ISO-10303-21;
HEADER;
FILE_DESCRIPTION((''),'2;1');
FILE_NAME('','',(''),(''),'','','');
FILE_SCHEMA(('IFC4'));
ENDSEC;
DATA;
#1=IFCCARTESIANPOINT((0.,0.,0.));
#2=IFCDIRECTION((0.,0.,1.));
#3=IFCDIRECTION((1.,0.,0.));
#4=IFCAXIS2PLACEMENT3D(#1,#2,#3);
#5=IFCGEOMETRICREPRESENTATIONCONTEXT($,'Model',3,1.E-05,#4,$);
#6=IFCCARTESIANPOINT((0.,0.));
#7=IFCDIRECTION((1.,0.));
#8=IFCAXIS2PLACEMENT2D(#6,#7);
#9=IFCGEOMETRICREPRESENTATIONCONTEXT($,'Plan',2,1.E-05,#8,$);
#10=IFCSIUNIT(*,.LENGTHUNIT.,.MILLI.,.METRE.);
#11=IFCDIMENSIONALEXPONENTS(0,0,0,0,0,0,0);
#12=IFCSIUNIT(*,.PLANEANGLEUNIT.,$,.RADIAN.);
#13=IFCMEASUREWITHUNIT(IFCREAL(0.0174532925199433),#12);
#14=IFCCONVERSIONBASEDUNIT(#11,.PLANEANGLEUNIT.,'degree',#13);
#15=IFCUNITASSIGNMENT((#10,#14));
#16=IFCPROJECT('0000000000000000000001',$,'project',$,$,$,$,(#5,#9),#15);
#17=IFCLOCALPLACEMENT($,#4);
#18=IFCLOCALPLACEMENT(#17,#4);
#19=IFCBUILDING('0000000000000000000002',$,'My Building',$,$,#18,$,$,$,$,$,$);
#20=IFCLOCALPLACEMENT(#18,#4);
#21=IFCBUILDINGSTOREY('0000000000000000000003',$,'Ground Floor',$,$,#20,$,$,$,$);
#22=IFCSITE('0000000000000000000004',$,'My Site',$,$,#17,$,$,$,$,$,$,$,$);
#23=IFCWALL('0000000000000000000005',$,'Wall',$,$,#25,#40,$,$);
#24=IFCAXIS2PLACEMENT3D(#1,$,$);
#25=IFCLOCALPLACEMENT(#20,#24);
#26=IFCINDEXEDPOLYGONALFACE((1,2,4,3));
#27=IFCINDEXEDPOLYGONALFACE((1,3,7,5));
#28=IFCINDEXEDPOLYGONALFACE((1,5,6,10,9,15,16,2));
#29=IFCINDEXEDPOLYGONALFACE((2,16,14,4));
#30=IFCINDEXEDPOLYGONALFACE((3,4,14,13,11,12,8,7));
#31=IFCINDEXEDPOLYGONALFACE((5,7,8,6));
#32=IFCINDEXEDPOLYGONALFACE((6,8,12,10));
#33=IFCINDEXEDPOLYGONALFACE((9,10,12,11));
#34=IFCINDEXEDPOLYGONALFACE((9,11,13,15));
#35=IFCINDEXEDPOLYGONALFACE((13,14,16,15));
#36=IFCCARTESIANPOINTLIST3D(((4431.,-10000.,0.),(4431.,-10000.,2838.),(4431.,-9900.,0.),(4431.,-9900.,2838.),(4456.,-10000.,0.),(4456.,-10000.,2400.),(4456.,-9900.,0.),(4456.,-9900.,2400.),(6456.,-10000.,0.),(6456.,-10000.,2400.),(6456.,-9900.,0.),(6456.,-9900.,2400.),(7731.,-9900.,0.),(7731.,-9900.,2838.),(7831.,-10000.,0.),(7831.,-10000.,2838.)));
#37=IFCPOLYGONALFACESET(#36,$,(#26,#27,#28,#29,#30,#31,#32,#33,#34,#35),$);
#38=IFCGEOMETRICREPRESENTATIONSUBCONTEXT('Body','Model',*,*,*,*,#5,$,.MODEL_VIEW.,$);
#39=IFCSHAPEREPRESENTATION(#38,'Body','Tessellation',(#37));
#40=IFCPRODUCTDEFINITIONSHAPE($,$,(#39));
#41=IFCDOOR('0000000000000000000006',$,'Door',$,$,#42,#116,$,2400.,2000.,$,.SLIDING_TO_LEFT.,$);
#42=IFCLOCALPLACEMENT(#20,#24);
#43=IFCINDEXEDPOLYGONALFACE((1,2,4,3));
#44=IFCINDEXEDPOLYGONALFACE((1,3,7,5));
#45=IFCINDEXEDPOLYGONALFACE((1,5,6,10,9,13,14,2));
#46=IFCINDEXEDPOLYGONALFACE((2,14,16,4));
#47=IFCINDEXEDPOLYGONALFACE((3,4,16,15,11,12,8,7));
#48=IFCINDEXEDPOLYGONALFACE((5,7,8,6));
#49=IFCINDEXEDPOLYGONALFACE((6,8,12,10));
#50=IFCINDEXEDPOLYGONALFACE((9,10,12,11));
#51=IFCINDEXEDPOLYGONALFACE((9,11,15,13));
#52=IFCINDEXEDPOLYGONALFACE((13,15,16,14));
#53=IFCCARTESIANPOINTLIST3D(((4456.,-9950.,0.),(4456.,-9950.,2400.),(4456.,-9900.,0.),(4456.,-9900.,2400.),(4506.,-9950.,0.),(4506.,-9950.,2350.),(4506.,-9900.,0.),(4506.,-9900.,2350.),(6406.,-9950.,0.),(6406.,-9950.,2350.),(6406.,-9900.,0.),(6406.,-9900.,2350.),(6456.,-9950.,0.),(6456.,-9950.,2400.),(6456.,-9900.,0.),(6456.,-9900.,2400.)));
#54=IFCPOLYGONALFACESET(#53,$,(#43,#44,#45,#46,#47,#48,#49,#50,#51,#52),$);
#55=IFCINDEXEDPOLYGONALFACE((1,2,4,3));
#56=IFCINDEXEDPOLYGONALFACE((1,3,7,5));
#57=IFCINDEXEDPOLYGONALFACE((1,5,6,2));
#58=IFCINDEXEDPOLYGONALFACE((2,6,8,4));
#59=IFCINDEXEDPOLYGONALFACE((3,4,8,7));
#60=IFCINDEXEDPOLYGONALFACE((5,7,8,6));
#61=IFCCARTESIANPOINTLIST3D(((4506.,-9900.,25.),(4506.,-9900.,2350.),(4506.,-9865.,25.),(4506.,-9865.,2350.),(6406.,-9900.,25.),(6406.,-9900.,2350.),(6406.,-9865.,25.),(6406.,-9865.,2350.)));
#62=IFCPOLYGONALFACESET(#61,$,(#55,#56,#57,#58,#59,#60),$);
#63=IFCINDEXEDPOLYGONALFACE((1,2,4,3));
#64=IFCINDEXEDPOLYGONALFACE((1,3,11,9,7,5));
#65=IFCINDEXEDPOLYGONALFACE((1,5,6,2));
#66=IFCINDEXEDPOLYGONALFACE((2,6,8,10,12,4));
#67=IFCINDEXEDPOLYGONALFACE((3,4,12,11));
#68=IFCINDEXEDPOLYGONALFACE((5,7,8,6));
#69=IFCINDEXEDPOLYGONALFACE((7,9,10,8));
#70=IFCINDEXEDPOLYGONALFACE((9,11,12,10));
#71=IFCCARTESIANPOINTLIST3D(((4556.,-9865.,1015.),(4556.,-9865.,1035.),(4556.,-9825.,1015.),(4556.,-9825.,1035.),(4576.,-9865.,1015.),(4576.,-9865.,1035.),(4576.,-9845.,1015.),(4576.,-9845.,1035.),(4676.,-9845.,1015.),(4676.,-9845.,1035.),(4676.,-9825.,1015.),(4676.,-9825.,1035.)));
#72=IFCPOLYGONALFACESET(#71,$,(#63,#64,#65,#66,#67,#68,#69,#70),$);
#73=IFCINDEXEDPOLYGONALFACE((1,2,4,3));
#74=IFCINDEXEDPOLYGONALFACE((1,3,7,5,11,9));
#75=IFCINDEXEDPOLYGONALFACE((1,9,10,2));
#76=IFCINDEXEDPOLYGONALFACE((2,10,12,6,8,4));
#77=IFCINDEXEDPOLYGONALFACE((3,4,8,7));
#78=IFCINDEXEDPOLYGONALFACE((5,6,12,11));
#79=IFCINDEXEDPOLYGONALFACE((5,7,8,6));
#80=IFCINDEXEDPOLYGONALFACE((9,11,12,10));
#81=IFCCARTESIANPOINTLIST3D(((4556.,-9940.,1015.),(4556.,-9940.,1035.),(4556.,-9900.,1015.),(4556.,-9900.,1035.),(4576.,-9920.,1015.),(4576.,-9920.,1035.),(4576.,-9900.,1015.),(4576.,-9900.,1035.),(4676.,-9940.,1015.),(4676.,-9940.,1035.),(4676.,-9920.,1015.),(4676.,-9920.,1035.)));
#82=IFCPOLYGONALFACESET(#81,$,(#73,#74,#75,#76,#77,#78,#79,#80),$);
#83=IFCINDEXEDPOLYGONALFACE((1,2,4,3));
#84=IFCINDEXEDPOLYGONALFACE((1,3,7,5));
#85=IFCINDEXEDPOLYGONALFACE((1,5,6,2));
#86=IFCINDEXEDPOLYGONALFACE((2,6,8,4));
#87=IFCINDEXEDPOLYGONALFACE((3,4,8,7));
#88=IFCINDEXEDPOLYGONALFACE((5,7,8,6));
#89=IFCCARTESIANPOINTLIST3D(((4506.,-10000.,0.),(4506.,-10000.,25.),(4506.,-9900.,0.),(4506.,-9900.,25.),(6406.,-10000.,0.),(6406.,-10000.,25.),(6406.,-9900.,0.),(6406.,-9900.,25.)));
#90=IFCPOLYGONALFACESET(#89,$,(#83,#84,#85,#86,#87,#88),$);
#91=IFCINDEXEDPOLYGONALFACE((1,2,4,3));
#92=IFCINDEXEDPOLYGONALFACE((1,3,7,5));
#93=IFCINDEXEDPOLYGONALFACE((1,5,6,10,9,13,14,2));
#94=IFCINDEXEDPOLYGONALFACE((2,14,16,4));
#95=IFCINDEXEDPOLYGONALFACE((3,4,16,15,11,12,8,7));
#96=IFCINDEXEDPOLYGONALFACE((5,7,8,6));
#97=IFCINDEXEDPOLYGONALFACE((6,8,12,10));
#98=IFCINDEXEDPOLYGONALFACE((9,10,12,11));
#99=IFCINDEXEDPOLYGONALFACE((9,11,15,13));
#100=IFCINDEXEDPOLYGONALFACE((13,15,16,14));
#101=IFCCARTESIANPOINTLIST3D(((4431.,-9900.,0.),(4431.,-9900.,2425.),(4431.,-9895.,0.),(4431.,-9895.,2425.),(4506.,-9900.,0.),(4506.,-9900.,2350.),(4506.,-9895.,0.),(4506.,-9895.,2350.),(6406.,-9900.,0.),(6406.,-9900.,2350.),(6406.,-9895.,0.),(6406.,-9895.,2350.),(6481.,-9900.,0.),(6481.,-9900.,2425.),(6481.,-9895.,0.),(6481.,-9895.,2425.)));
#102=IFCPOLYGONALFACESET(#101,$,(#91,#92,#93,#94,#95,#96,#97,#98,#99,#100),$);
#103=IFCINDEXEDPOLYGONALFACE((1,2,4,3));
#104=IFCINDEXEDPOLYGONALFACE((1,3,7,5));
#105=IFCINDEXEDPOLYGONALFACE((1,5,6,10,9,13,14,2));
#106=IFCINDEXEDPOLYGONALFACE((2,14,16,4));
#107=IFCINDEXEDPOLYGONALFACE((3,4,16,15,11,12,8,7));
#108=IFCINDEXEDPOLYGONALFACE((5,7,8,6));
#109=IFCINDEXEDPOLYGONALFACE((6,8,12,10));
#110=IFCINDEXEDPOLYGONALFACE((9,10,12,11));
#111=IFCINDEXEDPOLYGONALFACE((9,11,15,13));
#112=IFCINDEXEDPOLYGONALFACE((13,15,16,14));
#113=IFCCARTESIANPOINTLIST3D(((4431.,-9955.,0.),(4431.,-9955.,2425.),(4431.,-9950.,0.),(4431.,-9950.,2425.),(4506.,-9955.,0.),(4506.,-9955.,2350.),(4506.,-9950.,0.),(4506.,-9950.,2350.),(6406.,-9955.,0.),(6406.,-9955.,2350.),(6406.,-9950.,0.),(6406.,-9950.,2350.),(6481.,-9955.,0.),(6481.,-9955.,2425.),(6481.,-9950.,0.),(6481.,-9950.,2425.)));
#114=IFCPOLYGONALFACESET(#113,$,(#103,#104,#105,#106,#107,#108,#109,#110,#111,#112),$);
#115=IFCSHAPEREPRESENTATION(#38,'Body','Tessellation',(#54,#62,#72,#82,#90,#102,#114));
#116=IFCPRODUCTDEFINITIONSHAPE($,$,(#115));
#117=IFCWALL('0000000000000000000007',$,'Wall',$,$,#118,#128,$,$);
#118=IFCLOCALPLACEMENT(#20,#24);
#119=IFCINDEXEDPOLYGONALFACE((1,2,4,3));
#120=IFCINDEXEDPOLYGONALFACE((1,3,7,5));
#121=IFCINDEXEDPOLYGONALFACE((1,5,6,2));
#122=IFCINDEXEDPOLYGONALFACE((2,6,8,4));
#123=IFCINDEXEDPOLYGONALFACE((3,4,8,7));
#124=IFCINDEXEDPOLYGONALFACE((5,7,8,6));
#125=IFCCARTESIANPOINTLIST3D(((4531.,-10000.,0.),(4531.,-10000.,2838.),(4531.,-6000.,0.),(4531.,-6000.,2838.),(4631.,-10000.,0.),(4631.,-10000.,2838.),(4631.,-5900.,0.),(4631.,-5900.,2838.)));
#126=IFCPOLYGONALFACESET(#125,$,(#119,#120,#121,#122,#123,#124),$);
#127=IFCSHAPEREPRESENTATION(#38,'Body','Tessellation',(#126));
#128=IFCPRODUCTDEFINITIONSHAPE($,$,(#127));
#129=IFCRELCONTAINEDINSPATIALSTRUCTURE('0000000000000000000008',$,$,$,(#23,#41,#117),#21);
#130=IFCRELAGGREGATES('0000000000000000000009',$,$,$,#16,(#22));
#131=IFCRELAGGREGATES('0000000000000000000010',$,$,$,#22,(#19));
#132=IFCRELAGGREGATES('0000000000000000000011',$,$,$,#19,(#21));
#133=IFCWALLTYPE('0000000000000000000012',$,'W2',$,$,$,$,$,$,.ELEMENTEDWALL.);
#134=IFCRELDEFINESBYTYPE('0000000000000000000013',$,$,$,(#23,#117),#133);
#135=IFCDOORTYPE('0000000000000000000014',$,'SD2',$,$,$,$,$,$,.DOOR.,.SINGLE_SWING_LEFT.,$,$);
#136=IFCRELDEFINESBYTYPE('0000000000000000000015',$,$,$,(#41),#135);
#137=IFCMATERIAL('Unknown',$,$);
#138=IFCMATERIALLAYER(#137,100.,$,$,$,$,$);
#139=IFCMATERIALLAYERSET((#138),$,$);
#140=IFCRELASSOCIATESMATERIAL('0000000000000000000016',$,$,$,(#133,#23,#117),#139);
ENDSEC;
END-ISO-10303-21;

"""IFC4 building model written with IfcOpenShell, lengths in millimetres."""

from ifc_helpers import new_model, entity, si_unit, converted_unit, frame, origin_with_axes, origin_2d_with_axis, place, context, subcontext, project, spatial, line, indexed_curve, outline, extrude, clip, halfspace, shape, source, transform, mapped, material, layer, layer_set, layer_usage, type_object, type_shapes, element, fill, save


model = new_model("IFC4")

# Units and contexts
model_context = context("Model", 3, precision=1e-05, world=origin_with_axes())
plan_context = context("Plan", 2, precision=1e-05, world=origin_2d_with_axis())
body_context_1 = subcontext(model_context, "Body", "Model", "MODEL_VIEW")
body_context_2 = subcontext(plan_context, "Body", "Plan", "PLAN_VIEW")
ifc_project = project(units=[si_unit("LENGTHUNIT", "METRE", prefix="MILLI"), converted_unit("PLANEANGLEUNIT", "degree", entity("IfcReal", 0.0174532925199433), si_unit("PLANEANGLEUNIT", "RADIAN"), dimensions=[0, 0, 0, 0, 0, 0, 0])], contexts=[model_context, plan_context])

# Site, building, storey
site_placement = place(None, origin_with_axes())
site = spatial("IfcSite", under=ifc_project, at=site_placement, Name="My Site")
building_placement = place(site_placement, origin_with_axes())
building = spatial("IfcBuilding", under=site, at=building_placement, Name="My Building")
storey_placement = place(building_placement, origin_with_axes())
storey = spatial("IfcBuildingStorey", under=building, at=storey_placement, Name="Ground Floor")

# Shared definitions
ifc_material = material(Name="Unknown")

# Shared definitions
ifc_layer_1 = layer(ifc_material, 100.0)
ifc_layer_set_1 = layer_set([ifc_layer_1])
wall_type = type_object("IfcWallType", Name="W2", PredefinedType="ELEMENTEDWALL", material=ifc_layer_set_1)

# Wall, opening, door
ifc_layer_usage_1 = layer_usage(ifc_layer_set_1, "AXIS2", "POSITIVE", 0.0)
wall_1_placement = place(storey_placement, frame((7831.0, -9900.0, 0.0), z_axis=(0.0, 0.0, 1.0), x_axis=(-1.0, 0.0, 0.0)))
wall_1 = element("IfcWall", 1, at=wall_1_placement, inside=storey, type_object=wall_type, material=ifc_layer_usage_1, Name="Wall", context=body_context_1, shape_type="Clipping", body=[
    clip(extrude(outline(indexed_curve([(0.0, 0.0), (0.0, 100.0), (3400.0, 100.0), (3400.0, 0.0), (0.0, 0.0)], self_intersect=False)), origin_with_axes(), (0.0, 0.0, 1.0), 2838.0), halfspace(frame((100.0, 0.0, 0.0), z_axis=(-0.707108, -0.707105, 0.0), x_axis=(-0.707105, 0.707108, 0.0)), False)),
])
shared_shape_1 = source(origin_with_axes(), body_context_1, "Body", "SolidModel", [
    extrude(outline(indexed_curve([(0.0, 0.0), (2000.0, 0.0), (2000.0, 2400.0), (0.0, 2400.0)], segments=[line(1, 2, 3, 4, 1)])), frame((0.0, -600.0, 0.0), z_axis=(0.0, -1.0, 0.0), x_axis=(1.0, 0.0, 0.0)), (0.0, 0.0, -1.0), 1200.0),
])
opening_1_placement = place(wall_1_placement, frame((1375.0, 0.0, 0.0), z_axis=(0.0, 0.0, 1.0), x_axis=(1.0, 0.0, 0.0)))
opening_1 = element("IfcOpeningElement", 2, at=opening_1_placement, cuts=wall_1, PredefinedType="OPENING", context=body_context_1, shape_type="MappedRepresentation", body=[
    mapped(shared_shape_1, transform((0.0, 0.0, 0.0), x_axis=(1.0, 0.0, 0.0), y_axis=(0.0, 1.0, 0.0), z_axis=(0.0, 0.0, 1.0), scale=1.0)),
])
door_type_1 = type_object("IfcDoorType", Name="SD2", OperationType="SINGLE_SWING_LEFT", PredefinedType="DOOR")
shared_shape_2 = source(origin_with_axes(), body_context_1, "Body", "SolidModel", [
    extrude(outline(indexed_curve([(0.0, 0.0), (0.0, 2400.0), (2000.0, 2400.0), (2000.0, 0.0), (1950.0, 0.0), (1950.0, 2350.0), (50.0, 2350.0), (50.0, 0.0)], segments=[line(1, 2, 3, 4, 5, 6, 7, 8, 1)])), frame((0.0, 0.0, 0.0), z_axis=(0.0, -1.0, 0.0), x_axis=(1.0, 0.0, 0.0)), (0.0, 0.0, -1.0), 50.0),
    extrude(outline(indexed_curve([(0.0, 0.0), (1900.0, 0.0), (1900.0, 35.0), (0.0, 35.0)], segments=[line(1, 2, 3, 4, 1)])), frame((50.0, -35.0, 25.0), z_axis=(0.0, 0.0, 1.0), x_axis=(1.0, 0.0, 0.0)), (0.0, 0.0, 1.0), 2325.0),
    extrude(outline(indexed_curve([(0.0, 0.0), (0.0, -40.0), (-120.0, -40.0), (-120.0, -20.0), (-20.0, -20.0), (-20.0, 0.0)], segments=[line(1, 2, 3, 4, 5, 6, 1)])), frame((1900.0, -35.0, 1015.0), z_axis=(0.0, 0.0, 1.0), x_axis=(1.0, 0.0, 0.0)), (0.0, 0.0, 1.0), 20.0),
    extrude(outline(indexed_curve([(0.0, 0.0), (0.0, 40.0), (-120.0, 40.0), (-120.0, 20.0), (-20.0, 20.0), (-20.0, 0.0)], segments=[line(1, 2, 3, 4, 5, 6, 1)])), frame((1900.0, 0.0, 1015.0), z_axis=(0.0, 0.0, 1.0), x_axis=(1.0, 0.0, 0.0)), (0.0, 0.0, 1.0), 20.0),
    extrude(outline(indexed_curve([(0.0, 0.0), (1900.0, 0.0), (1900.0, 100.0), (0.0, 100.0)], segments=[line(1, 2, 3, 4, 1)])), frame((50.0, 0.0, 0.0), z_axis=(0.0, 0.0, 1.0), x_axis=(1.0, 0.0, 0.0)), (0.0, 0.0, 1.0), 25.0),
    extrude(outline(indexed_curve([(0.0, 0.0), (0.0, 2425.0), (2050.0, 2425.0), (2050.0, 0.0), (1975.0, 0.0), (1975.0, 2350.0), (75.0, 2350.0), (75.0, 0.0)], segments=[line(1, 2, 3, 4, 5, 6, 7, 8, 1)])), frame((-25.0, -5.0, 0.0), z_axis=(0.0, -1.0, 0.0), x_axis=(1.0, 0.0, 0.0)), (0.0, 0.0, -1.0), 5.0),
    extrude(outline(indexed_curve([(0.0, 0.0), (0.0, 2425.0), (2050.0, 2425.0), (2050.0, 0.0), (1975.0, 0.0), (1975.0, 2350.0), (75.0, 2350.0), (75.0, 0.0)], segments=[line(1, 2, 3, 4, 5, 6, 7, 8, 1)])), frame((-25.0, 50.0, 0.0), z_axis=(0.0, -1.0, 0.0), x_axis=(1.0, 0.0, 0.0)), (0.0, 0.0, -1.0), 5.0),
])
shared_shape_3 = source(origin_with_axes(), body_context_2, "Body", "Curve2D", [
    entity("IfcIndexedPolyCurve", entity("IfcCartesianPointList2D", [[0.0, 0.0], [50.0, 0.0], [50.0, 50.0], [0.0, 50.0]]), [entity("IfcLineIndex", [1, 2, 3, 4, 1])]),
    entity("IfcIndexedPolyCurve", entity("IfcCartesianPointList2D", [[2000.0, 0.0], [1950.0, 0.0], [1950.0, 50.0], [2000.0, 50.0]]), [entity("IfcLineIndex", [1, 2, 3, 4, 1])]),
    entity("IfcIndexedPolyCurve", entity("IfcCartesianPointList2D", [[-900.0, -35.0], [1000.0, -35.0], [1000.0, 0.0], [-900.0, 0.0]]), [entity("IfcLineIndex", [1, 2, 3, 4, 1])]),
])
type_shapes(door_type_1, [shared_shape_2, shared_shape_3])
door_1_placement = place(opening_1_placement, frame((0.0, 0.0, 0.0), z_axis=(0.0, 0.0, 1.0), x_axis=(1.0, 0.0, 0.0)))
door_1 = element("IfcDoor", 3, at=door_1_placement, inside=storey, type_object=door_type_1, Name="Door", OperationType="SLIDING_TO_LEFT", OverallHeight=2400.0, OverallWidth=2000.0, shapes=[
    shape(body_context_1, "Body", "MappedRepresentation", [mapped(shared_shape_2, transform((0.0, 0.0, 0.0), x_axis=(1.0, 0.0, 0.0), y_axis=(0.0, 1.0, 0.0), z_axis=(0.0, 0.0, 1.0), scale=1.0))]),
    shape(body_context_2, "Body", "MappedRepresentation", [mapped(shared_shape_3, transform((0.0, 0.0, 0.0), x_axis=(1.0, 0.0, 0.0), y_axis=(0.0, 1.0, 0.0), z_axis=(0.0, 0.0, 1.0), scale=1.0))]),
])
fill(opening_1, door_1)

# Wall
ifc_layer_usage_2 = layer_usage(ifc_layer_set_1, "AXIS2", "POSITIVE", 0.0)
wall_2_placement = place(storey_placement, frame((4531.0, -5900.0, 0.0), z_axis=(0.0, 0.0, 1.0), x_axis=(0.0, -1.0, 0.0)))
element("IfcWall", 4, at=wall_2_placement, inside=storey, type_object=wall_type, material=ifc_layer_usage_2, Name="Wall", context=body_context_1, shape_type="Clipping", body=[
    clip(extrude(outline(indexed_curve([(0.0, 0.0), (0.0, 100.0), (4100.0, 100.0), (4100.0, 0.0), (0.0, 0.0)], self_intersect=False)), origin_with_axes(), (0.0, 0.0, 1.0), 2838.0), halfspace(frame((100.0, 0.0, 0.0), z_axis=(-0.707107, -0.707107, 0.0), x_axis=(-0.707107, 0.707107, 0.0)), False)),
])

save(model, "model.ifc")
